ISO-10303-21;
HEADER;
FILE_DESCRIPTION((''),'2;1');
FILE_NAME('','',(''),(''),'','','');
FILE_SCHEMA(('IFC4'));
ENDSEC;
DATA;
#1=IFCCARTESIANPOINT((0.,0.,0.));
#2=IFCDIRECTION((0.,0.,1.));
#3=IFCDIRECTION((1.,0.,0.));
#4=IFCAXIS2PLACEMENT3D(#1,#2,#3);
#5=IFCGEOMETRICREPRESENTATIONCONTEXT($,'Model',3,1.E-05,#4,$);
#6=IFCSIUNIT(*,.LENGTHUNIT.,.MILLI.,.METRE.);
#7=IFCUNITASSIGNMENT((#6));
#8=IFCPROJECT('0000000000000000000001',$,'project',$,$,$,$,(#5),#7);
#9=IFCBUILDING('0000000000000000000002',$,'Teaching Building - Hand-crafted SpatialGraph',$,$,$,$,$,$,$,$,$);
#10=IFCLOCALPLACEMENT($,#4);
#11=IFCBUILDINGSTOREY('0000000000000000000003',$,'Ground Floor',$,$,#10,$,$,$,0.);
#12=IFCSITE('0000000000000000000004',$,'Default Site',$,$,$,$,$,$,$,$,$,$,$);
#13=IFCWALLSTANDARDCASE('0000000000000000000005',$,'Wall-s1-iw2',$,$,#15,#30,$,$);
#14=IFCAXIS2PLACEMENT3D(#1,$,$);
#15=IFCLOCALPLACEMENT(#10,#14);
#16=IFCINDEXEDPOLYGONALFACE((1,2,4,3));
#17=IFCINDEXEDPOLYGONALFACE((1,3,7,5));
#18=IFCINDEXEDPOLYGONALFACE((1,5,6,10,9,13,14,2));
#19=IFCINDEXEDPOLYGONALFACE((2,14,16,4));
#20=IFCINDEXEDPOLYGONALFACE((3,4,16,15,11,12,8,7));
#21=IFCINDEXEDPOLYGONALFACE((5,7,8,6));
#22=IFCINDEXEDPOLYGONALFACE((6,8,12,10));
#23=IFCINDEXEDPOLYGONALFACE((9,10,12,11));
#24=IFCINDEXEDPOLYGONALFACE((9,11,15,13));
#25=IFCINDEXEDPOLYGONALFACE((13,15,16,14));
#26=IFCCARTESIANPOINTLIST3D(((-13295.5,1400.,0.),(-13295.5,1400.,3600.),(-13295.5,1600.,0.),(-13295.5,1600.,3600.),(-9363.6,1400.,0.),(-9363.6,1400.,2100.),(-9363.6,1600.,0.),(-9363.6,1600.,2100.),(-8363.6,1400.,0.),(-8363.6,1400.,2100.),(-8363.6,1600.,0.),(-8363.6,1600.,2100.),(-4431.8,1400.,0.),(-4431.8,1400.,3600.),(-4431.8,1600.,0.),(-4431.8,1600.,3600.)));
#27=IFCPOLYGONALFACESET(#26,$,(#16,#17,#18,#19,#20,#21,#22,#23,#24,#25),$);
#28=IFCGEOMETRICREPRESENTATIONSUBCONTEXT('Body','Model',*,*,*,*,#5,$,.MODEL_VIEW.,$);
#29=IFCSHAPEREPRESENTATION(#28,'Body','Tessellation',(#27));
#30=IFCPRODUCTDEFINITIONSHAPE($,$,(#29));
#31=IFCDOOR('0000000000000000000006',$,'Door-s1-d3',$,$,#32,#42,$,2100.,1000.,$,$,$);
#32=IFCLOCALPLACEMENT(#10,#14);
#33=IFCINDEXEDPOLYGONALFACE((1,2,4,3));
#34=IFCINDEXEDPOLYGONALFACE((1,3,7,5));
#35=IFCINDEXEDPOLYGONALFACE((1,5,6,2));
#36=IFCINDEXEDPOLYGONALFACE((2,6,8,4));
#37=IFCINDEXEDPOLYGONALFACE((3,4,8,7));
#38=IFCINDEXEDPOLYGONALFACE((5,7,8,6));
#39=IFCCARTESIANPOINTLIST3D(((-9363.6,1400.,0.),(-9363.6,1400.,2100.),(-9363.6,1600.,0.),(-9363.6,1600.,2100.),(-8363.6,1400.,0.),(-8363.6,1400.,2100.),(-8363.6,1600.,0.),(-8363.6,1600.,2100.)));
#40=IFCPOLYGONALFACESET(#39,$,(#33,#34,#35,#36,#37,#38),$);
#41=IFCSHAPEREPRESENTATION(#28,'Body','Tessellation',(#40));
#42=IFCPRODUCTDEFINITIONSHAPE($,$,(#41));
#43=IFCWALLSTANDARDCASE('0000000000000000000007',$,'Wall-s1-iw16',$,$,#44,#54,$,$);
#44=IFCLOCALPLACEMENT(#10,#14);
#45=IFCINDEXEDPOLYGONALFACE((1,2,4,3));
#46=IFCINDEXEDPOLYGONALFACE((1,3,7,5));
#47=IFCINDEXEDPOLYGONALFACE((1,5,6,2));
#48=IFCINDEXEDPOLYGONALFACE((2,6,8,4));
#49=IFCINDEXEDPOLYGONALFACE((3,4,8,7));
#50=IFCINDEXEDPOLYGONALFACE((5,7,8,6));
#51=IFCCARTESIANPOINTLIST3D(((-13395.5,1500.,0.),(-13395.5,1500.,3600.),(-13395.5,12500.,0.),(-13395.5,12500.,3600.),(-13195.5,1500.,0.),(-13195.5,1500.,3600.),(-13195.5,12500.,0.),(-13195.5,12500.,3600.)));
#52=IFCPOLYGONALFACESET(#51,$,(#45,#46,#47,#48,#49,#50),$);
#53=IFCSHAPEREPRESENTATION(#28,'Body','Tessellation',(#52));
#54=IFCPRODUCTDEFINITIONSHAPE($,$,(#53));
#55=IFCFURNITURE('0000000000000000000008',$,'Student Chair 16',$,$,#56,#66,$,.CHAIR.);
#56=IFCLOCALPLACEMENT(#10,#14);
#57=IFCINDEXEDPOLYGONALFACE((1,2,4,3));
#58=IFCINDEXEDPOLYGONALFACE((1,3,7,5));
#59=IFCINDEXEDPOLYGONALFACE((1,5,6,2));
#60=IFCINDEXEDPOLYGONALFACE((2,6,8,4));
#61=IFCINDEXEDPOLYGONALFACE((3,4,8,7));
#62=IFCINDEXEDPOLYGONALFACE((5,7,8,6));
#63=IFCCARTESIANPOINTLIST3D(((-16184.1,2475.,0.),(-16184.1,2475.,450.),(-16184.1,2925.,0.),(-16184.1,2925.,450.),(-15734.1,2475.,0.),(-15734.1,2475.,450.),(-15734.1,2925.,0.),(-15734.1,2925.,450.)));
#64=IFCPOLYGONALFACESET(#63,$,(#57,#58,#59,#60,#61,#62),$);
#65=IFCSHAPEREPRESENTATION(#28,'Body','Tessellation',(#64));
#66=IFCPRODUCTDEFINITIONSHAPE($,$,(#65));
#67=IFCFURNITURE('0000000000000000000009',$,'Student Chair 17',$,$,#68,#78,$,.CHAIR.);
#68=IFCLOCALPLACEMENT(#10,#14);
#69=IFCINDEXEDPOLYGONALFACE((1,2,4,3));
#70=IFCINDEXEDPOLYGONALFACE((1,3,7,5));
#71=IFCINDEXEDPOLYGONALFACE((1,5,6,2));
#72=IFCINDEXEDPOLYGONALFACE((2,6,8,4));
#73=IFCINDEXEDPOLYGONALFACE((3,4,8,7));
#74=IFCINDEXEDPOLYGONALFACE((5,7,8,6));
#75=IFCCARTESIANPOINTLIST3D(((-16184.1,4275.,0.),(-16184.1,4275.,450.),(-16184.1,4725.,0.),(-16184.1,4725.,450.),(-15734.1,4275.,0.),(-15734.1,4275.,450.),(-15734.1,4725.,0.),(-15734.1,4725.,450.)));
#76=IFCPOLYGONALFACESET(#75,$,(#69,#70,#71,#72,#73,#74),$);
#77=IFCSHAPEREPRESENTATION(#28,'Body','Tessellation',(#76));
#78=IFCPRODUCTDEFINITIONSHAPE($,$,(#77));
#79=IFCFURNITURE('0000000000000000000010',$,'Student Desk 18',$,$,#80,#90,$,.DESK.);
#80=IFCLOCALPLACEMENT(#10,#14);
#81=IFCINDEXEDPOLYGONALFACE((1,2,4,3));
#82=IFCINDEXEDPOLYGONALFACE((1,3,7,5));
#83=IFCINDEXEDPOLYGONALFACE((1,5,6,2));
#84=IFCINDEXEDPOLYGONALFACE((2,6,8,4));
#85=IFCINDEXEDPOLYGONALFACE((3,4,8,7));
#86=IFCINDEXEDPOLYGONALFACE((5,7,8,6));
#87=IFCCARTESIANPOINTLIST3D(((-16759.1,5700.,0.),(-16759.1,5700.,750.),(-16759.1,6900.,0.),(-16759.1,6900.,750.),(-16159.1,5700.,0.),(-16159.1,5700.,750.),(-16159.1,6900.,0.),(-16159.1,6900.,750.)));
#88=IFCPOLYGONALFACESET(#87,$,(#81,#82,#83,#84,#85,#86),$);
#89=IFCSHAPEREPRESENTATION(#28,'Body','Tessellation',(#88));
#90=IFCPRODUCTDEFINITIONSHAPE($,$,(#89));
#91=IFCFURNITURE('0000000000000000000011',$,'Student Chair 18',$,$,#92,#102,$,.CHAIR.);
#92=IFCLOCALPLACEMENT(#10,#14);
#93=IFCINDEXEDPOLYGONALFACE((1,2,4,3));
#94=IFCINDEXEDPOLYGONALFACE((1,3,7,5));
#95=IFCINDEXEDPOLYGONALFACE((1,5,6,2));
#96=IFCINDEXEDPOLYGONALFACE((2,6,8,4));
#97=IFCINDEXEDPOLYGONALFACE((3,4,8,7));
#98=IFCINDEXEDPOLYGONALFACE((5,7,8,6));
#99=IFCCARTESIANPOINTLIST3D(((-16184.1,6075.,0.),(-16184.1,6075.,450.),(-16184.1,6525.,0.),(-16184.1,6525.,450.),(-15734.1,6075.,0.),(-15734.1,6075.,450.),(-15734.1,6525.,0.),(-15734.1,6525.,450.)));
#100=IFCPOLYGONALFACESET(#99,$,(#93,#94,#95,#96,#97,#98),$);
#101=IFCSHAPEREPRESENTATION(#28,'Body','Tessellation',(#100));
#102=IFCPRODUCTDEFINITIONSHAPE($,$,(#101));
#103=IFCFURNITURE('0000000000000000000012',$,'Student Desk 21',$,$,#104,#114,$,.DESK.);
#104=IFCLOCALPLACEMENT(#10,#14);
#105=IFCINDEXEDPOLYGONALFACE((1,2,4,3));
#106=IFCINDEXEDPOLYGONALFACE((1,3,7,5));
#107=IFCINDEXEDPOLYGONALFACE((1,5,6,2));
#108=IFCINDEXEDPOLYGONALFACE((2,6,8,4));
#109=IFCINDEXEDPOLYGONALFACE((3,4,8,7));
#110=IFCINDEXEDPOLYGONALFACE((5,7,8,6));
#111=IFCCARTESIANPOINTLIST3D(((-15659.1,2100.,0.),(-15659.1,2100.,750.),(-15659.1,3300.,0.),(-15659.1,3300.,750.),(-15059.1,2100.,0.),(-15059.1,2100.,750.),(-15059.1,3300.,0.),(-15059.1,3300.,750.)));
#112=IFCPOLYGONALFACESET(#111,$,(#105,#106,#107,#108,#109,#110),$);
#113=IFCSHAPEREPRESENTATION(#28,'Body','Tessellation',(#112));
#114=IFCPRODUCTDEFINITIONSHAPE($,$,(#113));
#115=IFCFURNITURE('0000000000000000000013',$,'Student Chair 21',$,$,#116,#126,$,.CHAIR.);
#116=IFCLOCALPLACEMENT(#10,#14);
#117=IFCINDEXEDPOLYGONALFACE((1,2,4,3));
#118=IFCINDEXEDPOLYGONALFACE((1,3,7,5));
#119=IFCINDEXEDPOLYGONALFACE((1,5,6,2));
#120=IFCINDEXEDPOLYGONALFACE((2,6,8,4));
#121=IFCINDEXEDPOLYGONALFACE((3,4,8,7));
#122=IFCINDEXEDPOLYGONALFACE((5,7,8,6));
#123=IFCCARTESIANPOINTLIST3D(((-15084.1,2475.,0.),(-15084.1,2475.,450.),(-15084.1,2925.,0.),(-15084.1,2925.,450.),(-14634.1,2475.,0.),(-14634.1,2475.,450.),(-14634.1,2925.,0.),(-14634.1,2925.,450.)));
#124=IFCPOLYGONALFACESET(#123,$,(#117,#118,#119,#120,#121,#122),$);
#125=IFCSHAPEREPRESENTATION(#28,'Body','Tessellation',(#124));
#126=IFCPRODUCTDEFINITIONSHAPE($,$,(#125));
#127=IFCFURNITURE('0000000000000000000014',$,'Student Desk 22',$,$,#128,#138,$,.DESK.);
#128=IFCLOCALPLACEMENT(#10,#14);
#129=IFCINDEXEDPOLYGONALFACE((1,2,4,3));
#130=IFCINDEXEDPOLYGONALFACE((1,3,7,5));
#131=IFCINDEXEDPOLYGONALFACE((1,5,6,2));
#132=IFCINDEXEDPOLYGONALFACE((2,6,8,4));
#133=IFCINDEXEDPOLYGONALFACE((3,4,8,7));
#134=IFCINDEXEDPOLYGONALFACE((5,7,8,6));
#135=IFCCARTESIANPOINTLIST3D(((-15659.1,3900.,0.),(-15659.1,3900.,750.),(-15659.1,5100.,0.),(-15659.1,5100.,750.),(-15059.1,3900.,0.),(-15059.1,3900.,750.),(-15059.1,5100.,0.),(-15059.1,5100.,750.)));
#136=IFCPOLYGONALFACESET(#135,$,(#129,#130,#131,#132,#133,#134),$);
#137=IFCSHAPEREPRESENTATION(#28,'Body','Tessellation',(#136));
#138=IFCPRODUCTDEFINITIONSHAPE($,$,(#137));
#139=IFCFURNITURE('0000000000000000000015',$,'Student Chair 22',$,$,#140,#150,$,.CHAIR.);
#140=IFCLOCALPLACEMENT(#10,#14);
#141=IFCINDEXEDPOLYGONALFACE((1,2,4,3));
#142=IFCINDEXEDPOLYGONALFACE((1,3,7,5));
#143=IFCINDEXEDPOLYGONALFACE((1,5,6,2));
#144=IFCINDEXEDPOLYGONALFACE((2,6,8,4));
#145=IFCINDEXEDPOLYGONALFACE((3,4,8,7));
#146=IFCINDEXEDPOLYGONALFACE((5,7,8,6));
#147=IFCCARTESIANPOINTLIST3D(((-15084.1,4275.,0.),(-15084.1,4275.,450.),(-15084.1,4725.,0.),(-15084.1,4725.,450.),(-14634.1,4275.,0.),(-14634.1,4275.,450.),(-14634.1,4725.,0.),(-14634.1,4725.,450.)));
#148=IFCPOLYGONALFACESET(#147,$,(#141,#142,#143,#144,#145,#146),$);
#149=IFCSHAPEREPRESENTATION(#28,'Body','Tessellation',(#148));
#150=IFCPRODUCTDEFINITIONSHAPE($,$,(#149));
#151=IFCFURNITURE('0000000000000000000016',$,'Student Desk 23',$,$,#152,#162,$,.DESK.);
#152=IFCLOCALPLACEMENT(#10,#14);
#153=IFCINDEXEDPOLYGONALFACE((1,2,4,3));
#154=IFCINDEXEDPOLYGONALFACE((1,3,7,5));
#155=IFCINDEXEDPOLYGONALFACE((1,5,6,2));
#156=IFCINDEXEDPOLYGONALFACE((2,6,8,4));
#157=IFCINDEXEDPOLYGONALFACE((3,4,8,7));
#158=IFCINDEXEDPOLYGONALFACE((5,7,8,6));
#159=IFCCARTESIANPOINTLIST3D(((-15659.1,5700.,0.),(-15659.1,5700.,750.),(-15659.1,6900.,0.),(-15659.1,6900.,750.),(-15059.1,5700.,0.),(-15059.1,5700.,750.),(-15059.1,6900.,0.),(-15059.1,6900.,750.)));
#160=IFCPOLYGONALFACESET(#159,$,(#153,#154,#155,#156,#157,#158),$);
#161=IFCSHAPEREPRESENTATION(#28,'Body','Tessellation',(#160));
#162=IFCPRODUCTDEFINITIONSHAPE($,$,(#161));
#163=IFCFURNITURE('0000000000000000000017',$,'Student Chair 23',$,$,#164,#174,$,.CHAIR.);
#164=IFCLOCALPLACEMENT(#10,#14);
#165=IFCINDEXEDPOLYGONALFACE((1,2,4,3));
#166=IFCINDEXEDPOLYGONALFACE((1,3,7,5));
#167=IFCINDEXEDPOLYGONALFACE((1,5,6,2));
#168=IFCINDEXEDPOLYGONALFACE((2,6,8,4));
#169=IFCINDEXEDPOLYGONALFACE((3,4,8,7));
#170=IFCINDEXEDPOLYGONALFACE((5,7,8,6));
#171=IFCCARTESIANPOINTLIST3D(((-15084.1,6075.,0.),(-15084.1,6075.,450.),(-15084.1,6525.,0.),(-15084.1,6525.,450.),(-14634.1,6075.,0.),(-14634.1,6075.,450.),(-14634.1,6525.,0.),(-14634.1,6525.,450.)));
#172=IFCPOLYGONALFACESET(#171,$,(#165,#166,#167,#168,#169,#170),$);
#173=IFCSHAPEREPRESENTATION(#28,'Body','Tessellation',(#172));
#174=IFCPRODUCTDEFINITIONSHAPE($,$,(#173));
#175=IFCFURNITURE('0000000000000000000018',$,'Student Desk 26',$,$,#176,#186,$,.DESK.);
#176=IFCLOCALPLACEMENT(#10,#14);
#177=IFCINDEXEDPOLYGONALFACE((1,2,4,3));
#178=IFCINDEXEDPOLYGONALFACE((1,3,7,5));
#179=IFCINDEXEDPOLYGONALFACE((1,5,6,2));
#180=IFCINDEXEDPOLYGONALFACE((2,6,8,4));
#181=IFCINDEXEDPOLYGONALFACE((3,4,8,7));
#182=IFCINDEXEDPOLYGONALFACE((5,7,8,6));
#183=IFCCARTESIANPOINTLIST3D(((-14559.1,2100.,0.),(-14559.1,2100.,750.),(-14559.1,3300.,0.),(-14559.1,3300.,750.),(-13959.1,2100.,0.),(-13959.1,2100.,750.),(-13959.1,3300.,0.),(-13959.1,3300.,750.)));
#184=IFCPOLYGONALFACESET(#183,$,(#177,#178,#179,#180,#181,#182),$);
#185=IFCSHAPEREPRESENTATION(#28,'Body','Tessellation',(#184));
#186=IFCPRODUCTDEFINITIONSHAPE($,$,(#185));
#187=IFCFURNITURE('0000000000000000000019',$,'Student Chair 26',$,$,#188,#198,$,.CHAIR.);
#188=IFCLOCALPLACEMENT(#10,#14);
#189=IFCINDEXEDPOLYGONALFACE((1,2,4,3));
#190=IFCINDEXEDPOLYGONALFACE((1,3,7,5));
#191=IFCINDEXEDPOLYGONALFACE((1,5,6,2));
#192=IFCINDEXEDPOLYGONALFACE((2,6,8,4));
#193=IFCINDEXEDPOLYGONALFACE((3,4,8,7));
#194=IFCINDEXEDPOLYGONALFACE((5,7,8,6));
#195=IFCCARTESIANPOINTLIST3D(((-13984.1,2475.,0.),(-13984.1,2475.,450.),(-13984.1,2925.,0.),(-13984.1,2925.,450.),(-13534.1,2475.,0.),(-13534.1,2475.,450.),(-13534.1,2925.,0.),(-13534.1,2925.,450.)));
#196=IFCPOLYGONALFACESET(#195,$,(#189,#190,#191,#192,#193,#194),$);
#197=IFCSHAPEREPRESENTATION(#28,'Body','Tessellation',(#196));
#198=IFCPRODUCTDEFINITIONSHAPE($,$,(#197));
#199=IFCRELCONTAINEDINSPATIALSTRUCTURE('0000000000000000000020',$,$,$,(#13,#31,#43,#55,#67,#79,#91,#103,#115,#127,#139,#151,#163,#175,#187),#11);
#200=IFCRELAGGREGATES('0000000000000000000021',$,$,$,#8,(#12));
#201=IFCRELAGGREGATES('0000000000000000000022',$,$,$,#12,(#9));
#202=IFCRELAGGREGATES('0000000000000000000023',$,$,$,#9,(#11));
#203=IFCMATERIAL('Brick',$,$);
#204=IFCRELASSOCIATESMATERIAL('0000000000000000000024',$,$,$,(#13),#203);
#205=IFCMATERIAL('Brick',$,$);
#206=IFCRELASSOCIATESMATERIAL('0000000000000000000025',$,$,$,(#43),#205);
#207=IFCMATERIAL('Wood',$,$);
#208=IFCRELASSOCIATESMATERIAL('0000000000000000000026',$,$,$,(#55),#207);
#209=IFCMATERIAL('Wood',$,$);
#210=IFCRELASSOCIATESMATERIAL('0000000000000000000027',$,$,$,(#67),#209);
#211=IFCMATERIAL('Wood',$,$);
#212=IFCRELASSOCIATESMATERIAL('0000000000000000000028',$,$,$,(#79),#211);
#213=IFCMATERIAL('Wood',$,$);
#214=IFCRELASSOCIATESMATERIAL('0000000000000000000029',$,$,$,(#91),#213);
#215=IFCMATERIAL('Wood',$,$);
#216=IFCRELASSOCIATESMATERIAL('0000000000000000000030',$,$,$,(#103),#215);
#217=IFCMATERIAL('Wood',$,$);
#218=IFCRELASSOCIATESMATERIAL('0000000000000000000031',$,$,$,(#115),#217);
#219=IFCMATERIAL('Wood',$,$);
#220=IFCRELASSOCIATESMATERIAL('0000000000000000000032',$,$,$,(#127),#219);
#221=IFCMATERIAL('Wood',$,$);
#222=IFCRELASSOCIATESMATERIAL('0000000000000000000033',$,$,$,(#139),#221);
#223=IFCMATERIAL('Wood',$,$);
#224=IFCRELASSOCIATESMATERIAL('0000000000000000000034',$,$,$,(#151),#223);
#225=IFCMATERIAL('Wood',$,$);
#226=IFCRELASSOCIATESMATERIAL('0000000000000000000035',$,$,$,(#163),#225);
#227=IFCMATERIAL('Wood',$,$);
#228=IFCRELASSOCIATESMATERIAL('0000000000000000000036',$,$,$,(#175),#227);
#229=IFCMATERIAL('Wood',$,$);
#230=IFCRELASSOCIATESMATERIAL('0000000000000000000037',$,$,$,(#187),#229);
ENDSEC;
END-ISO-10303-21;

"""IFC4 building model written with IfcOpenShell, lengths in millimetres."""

from ifc_helpers import new_model, si_unit, frame, frame_2d, origin_with_axes, origin_2d, place, context, subcontext, project, spatial, rectangle, extrude, material, element, fill, save


model = new_model("IFC4")

# Units and contexts
model_context = context("Model", 3, precision=1e-05, world=origin_with_axes())
body_context = subcontext(model_context, "Body", "Model", "MODEL_VIEW")
ifc_project = project(units=[si_unit("LENGTHUNIT", "METRE", prefix="MILLI")], contexts=[model_context])

# Site, building, storey
site = spatial("IfcSite", under=ifc_project, Name="Default Site")
building = spatial("IfcBuilding", under=site, Name="Teaching Building - Hand-crafted SpatialGraph")
storey_placement = place(None, origin_with_axes())
storey = spatial("IfcBuildingStorey", under=building, at=storey_placement, Name="Ground Floor", Elevation=0.0)

# Wall, opening, door
ifc_material_1 = material(Name="Brick")
wall_1_placement = place(storey_placement, frame((-13295.5, 1500.0, 0.0), z_axis=(0.0, 0.0, 1.0), x_axis=(1.0, 0.0, 0.0)))
wall_1 = element("IfcWallStandardCase", 1, at=wall_1_placement, inside=storey, material=ifc_material_1, Name="Wall-s1-iw2", context=body_context, shape_type="SweptSolid", body=[
    extrude(rectangle(XDim=8863.6, YDim=200.0, at=frame_2d((4431.8, 0.0))), origin_with_axes(), (0.0, 0.0, 1.0), 3600.0),
])
opening_placement = place(wall_1_placement, frame((3931.8, 0.0, 0.0), z_axis=(0.0, 0.0, 1.0), x_axis=(1.0, 0.0, 0.0)))
opening = element("IfcOpeningElement", 2, at=opening_placement, cuts=wall_1, context=body_context, shape_type="SweptSolid", body=[
    extrude(rectangle(XDim=1000.0, YDim=400.0, at=frame_2d((500.0, 0.0))), origin_with_axes(), (0.0, 0.0, 1.0), 2100.0),
])
door_placement = place(storey_placement, frame((-9363.6, 1500.0, 0.0), z_axis=(0.0, 0.0, 1.0), x_axis=(1.0, 0.0, 0.0)))
door = element("IfcDoor", 3, at=door_placement, inside=storey, Name="Door-s1-d3", OverallHeight=2100.0, OverallWidth=1000.0, context=body_context, shape_type="SweptSolid", body=[
    extrude(rectangle(XDim=1000.0, YDim=200.0, at=frame_2d((500.0, 0.0))), origin_with_axes(), (0.0, 0.0, 1.0), 2100.0),
])
fill(opening, door)

# Wall
ifc_material_2 = material(Name="Brick")
wall_2_placement = place(storey_placement, frame((-13295.5, 1500.0, 0.0), z_axis=(0.0, 0.0, 1.0), x_axis=(0.0, 1.0, 0.0)))
element("IfcWallStandardCase", 4, at=wall_2_placement, inside=storey, material=ifc_material_2, Name="Wall-s1-iw16", context=body_context, shape_type="SweptSolid", body=[
    extrude(rectangle(XDim=11000.0, YDim=200.0, at=frame_2d((5500.0, 0.0))), origin_with_axes(), (0.0, 0.0, 1.0), 3600.0),
])

# Furniture
ifc_material_3 = material(Name="Wood")
furniture_1_placement = place(storey_placement, frame((-15959.1, 2700.0, 0.0), z_axis=(0.0, 0.0, 1.0), x_axis=(1.0, 0.0, 0.0)))
element("IfcFurniture", 5, at=furniture_1_placement, inside=storey, material=ifc_material_3, Name="Student Chair 16", PredefinedType="CHAIR", context=body_context, shape_type="SweptSolid", body=[
    extrude(rectangle(XDim=450.0, YDim=450.0, at=origin_2d()), origin_with_axes(), (0.0, 0.0, 1.0), 450.0),
])
ifc_material_4 = material(Name="Wood")
furniture_2_placement = place(storey_placement, frame((-15959.1, 4500.0, 0.0), z_axis=(0.0, 0.0, 1.0), x_axis=(1.0, 0.0, 0.0)))
element("IfcFurniture", 6, at=furniture_2_placement, inside=storey, material=ifc_material_4, Name="Student Chair 17", PredefinedType="CHAIR", context=body_context, shape_type="SweptSolid", body=[
    extrude(rectangle(XDim=450.0, YDim=450.0, at=origin_2d()), origin_with_axes(), (0.0, 0.0, 1.0), 450.0),
])
ifc_material_5 = material(Name="Wood")
furniture_3_placement = place(storey_placement, frame((-16459.1, 6300.0, 0.0), z_axis=(0.0, 0.0, 1.0), x_axis=(0.0, 1.0, 0.0)))
element("IfcFurniture", 7, at=furniture_3_placement, inside=storey, material=ifc_material_5, Name="Student Desk 18", PredefinedType="DESK", context=body_context, shape_type="SweptSolid", body=[
    extrude(rectangle(XDim=1200.0, YDim=600.0, at=origin_2d()), origin_with_axes(), (0.0, 0.0, 1.0), 750.0),
])
ifc_material_6 = material(Name="Wood")
furniture_4_placement = place(storey_placement, frame((-15959.1, 6300.0, 0.0), z_axis=(0.0, 0.0, 1.0), x_axis=(1.0, 0.0, 0.0)))
element("IfcFurniture", 8, at=furniture_4_placement, inside=storey, material=ifc_material_6, Name="Student Chair 18", PredefinedType="CHAIR", context=body_context, shape_type="SweptSolid", body=[
    extrude(rectangle(XDim=450.0, YDim=450.0, at=origin_2d()), origin_with_axes(), (0.0, 0.0, 1.0), 450.0),
])
ifc_material_7 = material(Name="Wood")
furniture_5_placement = place(storey_placement, frame((-15359.1, 2700.0, 0.0), z_axis=(0.0, 0.0, 1.0), x_axis=(0.0, 1.0, 0.0)))
element("IfcFurniture", 9, at=furniture_5_placement, inside=storey, material=ifc_material_7, Name="Student Desk 21", PredefinedType="DESK", context=body_context, shape_type="SweptSolid", body=[
    extrude(rectangle(XDim=1200.0, YDim=600.0, at=origin_2d()), origin_with_axes(), (0.0, 0.0, 1.0), 750.0),
])
ifc_material_8 = material(Name="Wood")
furniture_6_placement = place(storey_placement, frame((-14859.1, 2700.0, 0.0), z_axis=(0.0, 0.0, 1.0), x_axis=(1.0, 0.0, 0.0)))
element("IfcFurniture", 10, at=furniture_6_placement, inside=storey, material=ifc_material_8, Name="Student Chair 21", PredefinedType="CHAIR", context=body_context, shape_type="SweptSolid", body=[
    extrude(rectangle(XDim=450.0, YDim=450.0, at=origin_2d()), origin_with_axes(), (0.0, 0.0, 1.0), 450.0),
])
ifc_material_9 = material(Name="Wood")
furniture_7_placement = place(storey_placement, frame((-15359.1, 4500.0, 0.0), z_axis=(0.0, 0.0, 1.0), x_axis=(0.0, 1.0, 0.0)))
element("IfcFurniture", 11, at=furniture_7_placement, inside=storey, material=ifc_material_9, Name="Student Desk 22", PredefinedType="DESK", context=body_context, shape_type="SweptSolid", body=[
    extrude(rectangle(XDim=1200.0, YDim=600.0, at=origin_2d()), origin_with_axes(), (0.0, 0.0, 1.0), 750.0),
])
ifc_material_10 = material(Name="Wood")
furniture_8_placement = place(storey_placement, frame((-14859.1, 4500.0, 0.0), z_axis=(0.0, 0.0, 1.0), x_axis=(1.0, 0.0, 0.0)))
element("IfcFurniture", 12, at=furniture_8_placement, inside=storey, material=ifc_material_10, Name="Student Chair 22", PredefinedType="CHAIR", context=body_context, shape_type="SweptSolid", body=[
    extrude(rectangle(XDim=450.0, YDim=450.0, at=origin_2d()), origin_with_axes(), (0.0, 0.0, 1.0), 450.0),
])
ifc_material_11 = material(Name="Wood")
furniture_9_placement = place(storey_placement, frame((-15359.1, 6300.0, 0.0), z_axis=(0.0, 0.0, 1.0), x_axis=(0.0, 1.0, 0.0)))
element("IfcFurniture", 13, at=furniture_9_placement, inside=storey, material=ifc_material_11, Name="Student Desk 23", PredefinedType="DESK", context=body_context, shape_type="SweptSolid", body=[
    extrude(rectangle(XDim=1200.0, YDim=600.0, at=origin_2d()), origin_with_axes(), (0.0, 0.0, 1.0), 750.0),
])
ifc_material_12 = material(Name="Wood")
furniture_10_placement = place(storey_placement, frame((-14859.1, 6300.0, 0.0), z_axis=(0.0, 0.0, 1.0), x_axis=(1.0, 0.0, 0.0)))
element("IfcFurniture", 14, at=furniture_10_placement, inside=storey, material=ifc_material_12, Name="Student Chair 23", PredefinedType="CHAIR", context=body_context, shape_type="SweptSolid", body=[
    extrude(rectangle(XDim=450.0, YDim=450.0, at=origin_2d()), origin_with_axes(), (0.0, 0.0, 1.0), 450.0),
])
ifc_material_13 = material(Name="Wood")
furniture_11_placement = place(storey_placement, frame((-14259.1, 2700.0, 0.0), z_axis=(0.0, 0.0, 1.0), x_axis=(0.0, 1.0, 0.0)))
element("IfcFurniture", 15, at=furniture_11_placement, inside=storey, material=ifc_material_13, Name="Student Desk 26", PredefinedType="DESK", context=body_context, shape_type="SweptSolid", body=[
    extrude(rectangle(XDim=1200.0, YDim=600.0, at=origin_2d()), origin_with_axes(), (0.0, 0.0, 1.0), 750.0),
])
ifc_material_14 = material(Name="Wood")
furniture_12_placement = place(storey_placement, frame((-13759.1, 2700.0, 0.0), z_axis=(0.0, 0.0, 1.0), x_axis=(1.0, 0.0, 0.0)))
element("IfcFurniture", 16, at=furniture_12_placement, inside=storey, material=ifc_material_14, Name="Student Chair 26", PredefinedType="CHAIR", context=body_context, shape_type="SweptSolid", body=[
    extrude(rectangle(XDim=450.0, YDim=450.0, at=origin_2d()), origin_with_axes(), (0.0, 0.0, 1.0), 450.0),
])

save(model, "model.ifc")
